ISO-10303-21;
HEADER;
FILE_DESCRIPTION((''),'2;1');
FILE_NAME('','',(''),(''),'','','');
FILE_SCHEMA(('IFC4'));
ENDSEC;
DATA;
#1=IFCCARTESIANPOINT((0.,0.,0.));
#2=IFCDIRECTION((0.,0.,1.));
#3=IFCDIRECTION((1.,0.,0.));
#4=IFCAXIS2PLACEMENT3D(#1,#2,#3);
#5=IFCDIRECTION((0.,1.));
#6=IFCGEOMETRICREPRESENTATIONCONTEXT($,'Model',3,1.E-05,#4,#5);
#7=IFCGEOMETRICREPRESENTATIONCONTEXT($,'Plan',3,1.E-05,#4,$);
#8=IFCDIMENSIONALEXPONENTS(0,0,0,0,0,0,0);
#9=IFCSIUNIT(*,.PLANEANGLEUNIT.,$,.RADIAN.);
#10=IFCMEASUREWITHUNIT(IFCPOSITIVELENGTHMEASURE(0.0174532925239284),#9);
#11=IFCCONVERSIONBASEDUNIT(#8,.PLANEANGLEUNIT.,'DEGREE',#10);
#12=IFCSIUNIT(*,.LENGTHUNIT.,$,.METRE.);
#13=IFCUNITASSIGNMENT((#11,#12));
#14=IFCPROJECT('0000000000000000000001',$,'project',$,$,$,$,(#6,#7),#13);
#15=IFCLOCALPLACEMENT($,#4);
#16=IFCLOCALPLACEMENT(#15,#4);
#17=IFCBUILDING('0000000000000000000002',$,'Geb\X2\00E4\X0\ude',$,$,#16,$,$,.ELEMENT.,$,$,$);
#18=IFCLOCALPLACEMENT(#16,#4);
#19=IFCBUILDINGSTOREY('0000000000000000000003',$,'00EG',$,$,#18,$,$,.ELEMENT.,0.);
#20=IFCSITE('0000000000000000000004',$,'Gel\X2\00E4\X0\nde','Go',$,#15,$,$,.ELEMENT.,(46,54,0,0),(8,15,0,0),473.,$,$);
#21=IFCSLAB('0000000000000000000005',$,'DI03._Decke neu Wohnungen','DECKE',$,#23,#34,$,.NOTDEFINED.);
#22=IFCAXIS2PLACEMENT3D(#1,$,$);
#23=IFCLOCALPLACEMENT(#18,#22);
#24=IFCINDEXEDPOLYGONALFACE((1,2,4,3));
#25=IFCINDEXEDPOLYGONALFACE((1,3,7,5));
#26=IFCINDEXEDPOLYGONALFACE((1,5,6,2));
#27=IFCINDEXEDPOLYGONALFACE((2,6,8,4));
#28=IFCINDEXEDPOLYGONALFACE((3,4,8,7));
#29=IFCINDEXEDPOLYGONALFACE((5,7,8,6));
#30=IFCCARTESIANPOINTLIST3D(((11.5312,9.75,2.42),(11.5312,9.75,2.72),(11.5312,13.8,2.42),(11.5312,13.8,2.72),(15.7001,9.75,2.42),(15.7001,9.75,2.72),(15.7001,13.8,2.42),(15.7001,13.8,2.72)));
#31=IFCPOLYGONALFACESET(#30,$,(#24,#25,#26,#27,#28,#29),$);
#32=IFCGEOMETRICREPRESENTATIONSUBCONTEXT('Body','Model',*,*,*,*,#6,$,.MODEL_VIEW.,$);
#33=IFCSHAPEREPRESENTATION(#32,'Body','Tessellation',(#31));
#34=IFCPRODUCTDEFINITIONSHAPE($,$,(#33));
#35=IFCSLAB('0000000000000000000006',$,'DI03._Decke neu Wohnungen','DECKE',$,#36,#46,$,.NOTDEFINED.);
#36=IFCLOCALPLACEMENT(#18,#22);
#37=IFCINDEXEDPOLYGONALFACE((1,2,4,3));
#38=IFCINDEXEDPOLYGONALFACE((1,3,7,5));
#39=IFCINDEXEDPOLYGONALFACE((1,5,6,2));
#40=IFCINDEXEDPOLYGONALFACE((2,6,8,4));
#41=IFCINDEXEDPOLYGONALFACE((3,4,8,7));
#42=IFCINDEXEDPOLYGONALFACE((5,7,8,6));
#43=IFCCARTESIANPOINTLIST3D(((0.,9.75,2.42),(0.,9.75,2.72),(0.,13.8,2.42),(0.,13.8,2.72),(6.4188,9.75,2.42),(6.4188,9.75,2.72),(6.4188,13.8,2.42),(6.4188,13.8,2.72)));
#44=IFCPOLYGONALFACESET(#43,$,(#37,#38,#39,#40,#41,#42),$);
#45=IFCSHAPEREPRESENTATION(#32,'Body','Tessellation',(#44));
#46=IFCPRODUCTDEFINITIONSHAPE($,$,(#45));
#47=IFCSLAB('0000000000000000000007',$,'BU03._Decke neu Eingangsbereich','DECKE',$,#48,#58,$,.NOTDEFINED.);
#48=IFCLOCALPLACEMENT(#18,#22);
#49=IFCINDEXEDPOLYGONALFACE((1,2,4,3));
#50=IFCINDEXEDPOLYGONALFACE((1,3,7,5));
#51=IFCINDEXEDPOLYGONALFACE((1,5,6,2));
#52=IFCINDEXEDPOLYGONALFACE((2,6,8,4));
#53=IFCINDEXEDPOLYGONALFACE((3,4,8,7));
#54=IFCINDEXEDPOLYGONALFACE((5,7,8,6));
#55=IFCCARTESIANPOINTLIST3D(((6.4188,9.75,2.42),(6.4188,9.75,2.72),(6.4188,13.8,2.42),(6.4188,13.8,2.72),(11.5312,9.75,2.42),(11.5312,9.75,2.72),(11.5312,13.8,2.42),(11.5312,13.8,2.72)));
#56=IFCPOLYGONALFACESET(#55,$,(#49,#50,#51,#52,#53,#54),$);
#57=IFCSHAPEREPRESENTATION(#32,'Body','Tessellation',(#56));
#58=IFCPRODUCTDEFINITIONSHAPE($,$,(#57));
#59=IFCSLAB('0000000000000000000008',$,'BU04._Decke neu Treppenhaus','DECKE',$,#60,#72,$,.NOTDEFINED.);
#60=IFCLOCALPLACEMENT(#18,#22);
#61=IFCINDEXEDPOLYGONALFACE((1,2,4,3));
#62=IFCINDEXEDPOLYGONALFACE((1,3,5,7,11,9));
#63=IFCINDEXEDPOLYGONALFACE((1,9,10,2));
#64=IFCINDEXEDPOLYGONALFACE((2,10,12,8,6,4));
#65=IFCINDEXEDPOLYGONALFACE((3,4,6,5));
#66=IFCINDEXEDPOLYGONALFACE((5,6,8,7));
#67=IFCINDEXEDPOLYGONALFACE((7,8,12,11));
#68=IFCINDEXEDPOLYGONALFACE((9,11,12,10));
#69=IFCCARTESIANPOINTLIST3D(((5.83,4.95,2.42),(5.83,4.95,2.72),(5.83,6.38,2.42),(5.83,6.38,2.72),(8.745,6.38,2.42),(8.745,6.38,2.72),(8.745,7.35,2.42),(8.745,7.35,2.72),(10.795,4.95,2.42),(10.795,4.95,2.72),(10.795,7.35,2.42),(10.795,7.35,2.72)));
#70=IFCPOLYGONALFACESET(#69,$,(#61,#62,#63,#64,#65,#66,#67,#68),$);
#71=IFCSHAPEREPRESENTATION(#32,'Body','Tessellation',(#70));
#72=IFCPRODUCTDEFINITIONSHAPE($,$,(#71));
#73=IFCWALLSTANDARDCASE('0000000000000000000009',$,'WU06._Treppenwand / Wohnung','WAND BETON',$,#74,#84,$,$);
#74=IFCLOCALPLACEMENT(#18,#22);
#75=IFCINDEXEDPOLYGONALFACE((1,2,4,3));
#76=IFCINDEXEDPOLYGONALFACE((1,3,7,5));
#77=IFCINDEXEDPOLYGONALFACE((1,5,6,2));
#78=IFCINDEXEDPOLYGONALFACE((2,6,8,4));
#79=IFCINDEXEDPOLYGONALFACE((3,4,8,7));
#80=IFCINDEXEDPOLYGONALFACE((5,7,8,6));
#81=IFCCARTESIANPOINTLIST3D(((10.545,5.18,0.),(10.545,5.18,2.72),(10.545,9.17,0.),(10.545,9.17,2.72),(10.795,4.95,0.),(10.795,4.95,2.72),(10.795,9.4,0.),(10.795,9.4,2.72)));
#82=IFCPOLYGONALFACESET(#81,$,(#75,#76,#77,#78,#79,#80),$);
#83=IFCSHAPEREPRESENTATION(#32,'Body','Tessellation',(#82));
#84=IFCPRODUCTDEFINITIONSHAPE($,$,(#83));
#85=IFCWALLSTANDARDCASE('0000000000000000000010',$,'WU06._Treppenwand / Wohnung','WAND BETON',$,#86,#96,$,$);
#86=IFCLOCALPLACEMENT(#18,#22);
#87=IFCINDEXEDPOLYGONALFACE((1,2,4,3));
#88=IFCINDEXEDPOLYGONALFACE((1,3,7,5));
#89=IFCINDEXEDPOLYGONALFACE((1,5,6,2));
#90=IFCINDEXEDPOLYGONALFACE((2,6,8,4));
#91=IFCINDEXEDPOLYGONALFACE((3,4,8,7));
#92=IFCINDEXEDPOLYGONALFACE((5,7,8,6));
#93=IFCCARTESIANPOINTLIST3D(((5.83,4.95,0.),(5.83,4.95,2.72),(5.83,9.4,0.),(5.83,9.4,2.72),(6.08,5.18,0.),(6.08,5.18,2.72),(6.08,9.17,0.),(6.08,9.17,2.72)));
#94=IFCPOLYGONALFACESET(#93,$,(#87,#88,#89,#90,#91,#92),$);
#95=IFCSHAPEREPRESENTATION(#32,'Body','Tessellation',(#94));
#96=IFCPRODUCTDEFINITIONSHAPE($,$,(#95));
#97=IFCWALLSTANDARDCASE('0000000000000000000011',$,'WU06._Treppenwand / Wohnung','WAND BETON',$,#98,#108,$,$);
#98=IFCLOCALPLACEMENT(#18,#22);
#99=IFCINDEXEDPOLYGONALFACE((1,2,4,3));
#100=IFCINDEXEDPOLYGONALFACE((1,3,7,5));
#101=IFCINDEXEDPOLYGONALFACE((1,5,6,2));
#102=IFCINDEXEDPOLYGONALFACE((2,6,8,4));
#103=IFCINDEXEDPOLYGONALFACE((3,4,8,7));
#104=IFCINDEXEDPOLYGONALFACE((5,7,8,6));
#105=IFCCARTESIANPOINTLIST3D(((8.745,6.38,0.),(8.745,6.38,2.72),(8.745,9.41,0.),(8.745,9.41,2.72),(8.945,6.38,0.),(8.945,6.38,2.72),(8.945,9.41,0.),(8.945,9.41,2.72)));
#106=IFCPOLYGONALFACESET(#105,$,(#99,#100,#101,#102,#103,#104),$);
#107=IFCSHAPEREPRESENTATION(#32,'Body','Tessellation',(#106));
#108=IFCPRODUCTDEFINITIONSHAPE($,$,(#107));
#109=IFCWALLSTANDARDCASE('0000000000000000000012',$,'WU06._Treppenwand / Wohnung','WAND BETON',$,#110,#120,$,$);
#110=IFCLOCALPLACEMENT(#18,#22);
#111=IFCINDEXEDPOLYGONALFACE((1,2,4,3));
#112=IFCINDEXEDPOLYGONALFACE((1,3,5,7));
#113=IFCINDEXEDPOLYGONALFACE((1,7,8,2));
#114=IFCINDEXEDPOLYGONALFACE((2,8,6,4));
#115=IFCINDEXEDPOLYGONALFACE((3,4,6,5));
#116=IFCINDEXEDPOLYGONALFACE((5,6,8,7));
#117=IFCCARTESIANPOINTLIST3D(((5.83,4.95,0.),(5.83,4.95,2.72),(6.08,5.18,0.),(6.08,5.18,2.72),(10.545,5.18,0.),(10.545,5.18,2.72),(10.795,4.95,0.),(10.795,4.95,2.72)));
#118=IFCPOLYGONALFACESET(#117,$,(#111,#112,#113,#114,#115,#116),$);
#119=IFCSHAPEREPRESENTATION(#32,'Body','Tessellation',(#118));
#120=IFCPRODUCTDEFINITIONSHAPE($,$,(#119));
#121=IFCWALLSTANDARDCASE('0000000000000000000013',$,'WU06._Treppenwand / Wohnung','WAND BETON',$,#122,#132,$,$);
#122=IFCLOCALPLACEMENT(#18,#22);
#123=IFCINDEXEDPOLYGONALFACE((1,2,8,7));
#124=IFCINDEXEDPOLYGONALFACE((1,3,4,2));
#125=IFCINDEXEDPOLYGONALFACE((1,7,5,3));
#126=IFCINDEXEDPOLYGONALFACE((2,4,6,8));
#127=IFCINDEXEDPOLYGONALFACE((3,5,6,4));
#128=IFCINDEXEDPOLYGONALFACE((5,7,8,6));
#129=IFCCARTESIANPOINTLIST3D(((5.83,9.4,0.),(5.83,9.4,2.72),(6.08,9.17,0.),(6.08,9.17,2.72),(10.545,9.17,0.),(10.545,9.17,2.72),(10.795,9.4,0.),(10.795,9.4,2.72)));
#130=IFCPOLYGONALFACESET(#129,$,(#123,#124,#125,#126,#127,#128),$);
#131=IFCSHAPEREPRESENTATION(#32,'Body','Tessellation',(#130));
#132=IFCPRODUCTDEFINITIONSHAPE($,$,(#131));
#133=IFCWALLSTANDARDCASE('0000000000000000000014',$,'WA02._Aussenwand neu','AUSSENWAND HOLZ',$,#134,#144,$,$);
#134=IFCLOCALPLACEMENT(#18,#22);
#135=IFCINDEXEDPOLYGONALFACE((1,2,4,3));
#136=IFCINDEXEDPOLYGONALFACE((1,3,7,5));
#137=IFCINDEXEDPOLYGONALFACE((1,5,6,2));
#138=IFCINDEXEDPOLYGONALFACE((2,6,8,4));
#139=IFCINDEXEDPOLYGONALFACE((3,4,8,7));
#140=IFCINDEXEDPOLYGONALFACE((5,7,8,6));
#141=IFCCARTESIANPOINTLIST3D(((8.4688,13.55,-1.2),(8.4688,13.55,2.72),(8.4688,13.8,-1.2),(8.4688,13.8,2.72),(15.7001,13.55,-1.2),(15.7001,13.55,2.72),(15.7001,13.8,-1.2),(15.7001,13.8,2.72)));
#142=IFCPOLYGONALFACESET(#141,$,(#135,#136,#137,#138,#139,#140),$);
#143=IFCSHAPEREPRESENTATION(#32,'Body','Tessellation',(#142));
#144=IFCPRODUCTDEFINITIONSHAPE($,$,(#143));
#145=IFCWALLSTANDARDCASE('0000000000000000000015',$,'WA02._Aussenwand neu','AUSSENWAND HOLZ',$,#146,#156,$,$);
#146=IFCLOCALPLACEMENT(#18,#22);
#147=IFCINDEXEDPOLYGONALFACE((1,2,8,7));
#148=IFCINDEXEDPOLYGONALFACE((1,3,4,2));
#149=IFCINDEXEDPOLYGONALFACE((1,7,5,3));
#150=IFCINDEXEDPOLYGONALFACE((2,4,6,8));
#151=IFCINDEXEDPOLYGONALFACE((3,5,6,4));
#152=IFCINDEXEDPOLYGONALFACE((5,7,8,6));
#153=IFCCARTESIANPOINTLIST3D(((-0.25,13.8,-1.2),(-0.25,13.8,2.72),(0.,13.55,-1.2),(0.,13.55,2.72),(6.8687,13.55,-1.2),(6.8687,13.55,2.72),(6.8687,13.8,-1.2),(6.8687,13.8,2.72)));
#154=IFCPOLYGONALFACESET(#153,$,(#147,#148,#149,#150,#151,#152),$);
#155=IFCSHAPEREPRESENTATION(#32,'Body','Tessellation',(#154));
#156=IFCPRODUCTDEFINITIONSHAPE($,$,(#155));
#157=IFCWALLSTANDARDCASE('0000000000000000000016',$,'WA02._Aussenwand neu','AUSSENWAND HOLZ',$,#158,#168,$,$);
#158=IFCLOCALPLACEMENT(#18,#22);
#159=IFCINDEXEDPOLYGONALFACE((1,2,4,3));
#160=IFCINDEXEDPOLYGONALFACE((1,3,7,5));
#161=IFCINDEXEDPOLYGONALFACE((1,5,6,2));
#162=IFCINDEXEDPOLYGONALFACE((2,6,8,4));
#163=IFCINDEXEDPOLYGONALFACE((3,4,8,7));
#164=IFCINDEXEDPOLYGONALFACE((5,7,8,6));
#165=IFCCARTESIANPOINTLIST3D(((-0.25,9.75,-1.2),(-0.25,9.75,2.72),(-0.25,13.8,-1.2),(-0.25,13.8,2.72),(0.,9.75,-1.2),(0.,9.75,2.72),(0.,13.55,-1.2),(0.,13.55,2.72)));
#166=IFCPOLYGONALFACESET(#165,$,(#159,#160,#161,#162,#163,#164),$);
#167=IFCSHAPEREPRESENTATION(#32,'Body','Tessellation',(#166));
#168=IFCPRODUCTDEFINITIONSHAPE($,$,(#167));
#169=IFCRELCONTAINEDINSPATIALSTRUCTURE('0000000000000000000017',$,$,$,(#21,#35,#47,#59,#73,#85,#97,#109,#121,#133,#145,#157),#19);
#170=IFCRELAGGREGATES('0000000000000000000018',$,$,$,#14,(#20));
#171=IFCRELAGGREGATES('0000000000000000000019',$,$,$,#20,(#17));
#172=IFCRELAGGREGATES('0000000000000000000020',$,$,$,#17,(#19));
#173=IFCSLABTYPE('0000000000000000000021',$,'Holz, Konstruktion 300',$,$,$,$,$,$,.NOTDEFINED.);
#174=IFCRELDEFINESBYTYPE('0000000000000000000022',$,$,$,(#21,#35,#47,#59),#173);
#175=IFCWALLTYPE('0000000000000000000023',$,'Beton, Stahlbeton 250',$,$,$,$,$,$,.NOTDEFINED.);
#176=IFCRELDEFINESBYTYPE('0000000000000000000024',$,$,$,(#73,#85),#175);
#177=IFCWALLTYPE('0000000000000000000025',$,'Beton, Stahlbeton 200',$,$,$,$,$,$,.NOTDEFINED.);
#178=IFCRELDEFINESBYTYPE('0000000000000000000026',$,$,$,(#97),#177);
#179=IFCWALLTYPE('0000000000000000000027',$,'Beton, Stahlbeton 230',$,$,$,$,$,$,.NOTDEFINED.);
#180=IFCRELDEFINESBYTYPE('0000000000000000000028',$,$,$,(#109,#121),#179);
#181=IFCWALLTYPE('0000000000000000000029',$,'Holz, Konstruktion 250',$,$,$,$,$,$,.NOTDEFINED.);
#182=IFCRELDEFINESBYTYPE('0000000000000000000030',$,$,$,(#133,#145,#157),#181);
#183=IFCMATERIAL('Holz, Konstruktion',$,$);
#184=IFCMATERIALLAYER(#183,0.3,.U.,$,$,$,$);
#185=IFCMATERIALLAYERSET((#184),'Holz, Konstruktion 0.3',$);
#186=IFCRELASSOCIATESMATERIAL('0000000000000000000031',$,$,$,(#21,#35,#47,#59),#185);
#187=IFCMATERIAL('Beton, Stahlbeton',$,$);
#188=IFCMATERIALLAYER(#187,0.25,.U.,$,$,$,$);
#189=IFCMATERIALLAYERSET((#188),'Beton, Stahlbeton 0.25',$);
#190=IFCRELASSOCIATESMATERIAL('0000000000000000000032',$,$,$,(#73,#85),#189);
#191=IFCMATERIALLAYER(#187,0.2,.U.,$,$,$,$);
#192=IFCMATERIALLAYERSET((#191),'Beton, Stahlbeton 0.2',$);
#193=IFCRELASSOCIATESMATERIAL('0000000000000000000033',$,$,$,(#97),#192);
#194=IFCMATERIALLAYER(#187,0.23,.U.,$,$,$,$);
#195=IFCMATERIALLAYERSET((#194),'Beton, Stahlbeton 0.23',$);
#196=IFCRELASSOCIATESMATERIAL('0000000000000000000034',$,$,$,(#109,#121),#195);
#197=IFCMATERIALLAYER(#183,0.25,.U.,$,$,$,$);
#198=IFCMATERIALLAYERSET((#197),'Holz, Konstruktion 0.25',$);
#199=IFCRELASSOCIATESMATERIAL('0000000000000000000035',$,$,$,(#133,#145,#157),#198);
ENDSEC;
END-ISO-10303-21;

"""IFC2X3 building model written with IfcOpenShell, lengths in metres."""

from ifc_helpers import new_model, entity, si_unit, converted_unit, direction, frame, origin_with_axes, place, context, subcontext, project, spatial, polyline, outline, extrude, material, layer, layer_set, layer_usage, type_object, element, save


model = new_model("IFC2X3")

# Units and contexts
model_context = context("Model", 3, precision=1e-05, world=origin_with_axes(), true_north=direction((0.0, 1.0)))
plan_context = context("Plan", 3, precision=1e-05, world=origin_with_axes())
body_context = subcontext(model_context, "Body", "Model", "MODEL_VIEW")
ifc_project = project(units=[converted_unit("PLANEANGLEUNIT", "DEGREE", entity("IfcPositiveLengthMeasure", 0.0174532925239284), si_unit("PLANEANGLEUNIT", "RADIAN"), dimensions=[0, 0, 0, 0, 0, 0, 0]), si_unit("LENGTHUNIT", "METRE")], contexts=[model_context, plan_context])

# Site, building, storey
site_placement = place(None, origin_with_axes())
site = spatial("IfcSite", under=ifc_project, at=site_placement, Name="Gelände", Description="Go", CompositionType="ELEMENT", RefLatitude=(46, 54, 0, 0), RefLongitude=(8, 15, 0, 0), RefElevation=473.0)
building_placement = place(site_placement, origin_with_axes())
building = spatial("IfcBuilding", under=site, at=building_placement, Name="Gebäude", CompositionType="ELEMENT")
storey_placement = place(building_placement, origin_with_axes())
storey = spatial("IfcBuildingStorey", under=building, at=storey_placement, Name="00EG", CompositionType="ELEMENT", Elevation=0.0)

# Slabs
ifc_material_1 = material(Name="Holz, Konstruktion")
ifc_layer_1 = layer(ifc_material_1, 0.3, ventilated="UNKNOWN")
ifc_layer_set_1 = layer_set([ifc_layer_1], Name="Holz, Konstruktion 0.3")
ifc_layer_usage_1 = layer_usage(ifc_layer_set_1, "AXIS3", "NEGATIVE", 0.3)
slab_type = type_object("IfcSlabType", Name="Holz, Konstruktion 300", PredefinedType="NOTDEFINED")
slab_1_placement = place(storey_placement, frame((11.5312, 9.75, 2.72), z_axis=(0.0, 0.0, 1.0), x_axis=(1.0, 0.0, 0.0)))
element("IfcSlab", 1, at=slab_1_placement, inside=storey, type_object=slab_type, material=ifc_layer_usage_1, Name="DI03._Decke neu Wohnungen", Description="DECKE", PredefinedType="NOTDEFINED", context=body_context, shape_type="SweptSolid", body=[
    extrude(outline(polyline([(0.0, 0.0), (4.1689, 0.0), (4.1689, 4.05), (0.0, 4.05), (0.0, 0.0)])), frame((0.0, 0.0, -0.3), z_axis=(0.0, 0.0, 1.0), x_axis=(1.0, 0.0, 0.0)), (0.0, 0.0, 1.0), 0.3),
])
ifc_layer_usage_2 = layer_usage(ifc_layer_set_1, "AXIS3", "NEGATIVE", 0.3)
slab_2_placement = place(storey_placement, frame((0.0, 9.75, 2.72), z_axis=(0.0, 0.0, 1.0), x_axis=(1.0, 0.0, 0.0)))
element("IfcSlab", 2, at=slab_2_placement, inside=storey, type_object=slab_type, material=ifc_layer_usage_2, Name="DI03._Decke neu Wohnungen", Description="DECKE", PredefinedType="NOTDEFINED", context=body_context, shape_type="SweptSolid", body=[
    extrude(outline(polyline([(0.0, 0.0), (6.4188, 0.0), (6.4188, 4.05), (0.0, 4.05), (0.0, 0.0)])), frame((0.0, 0.0, -0.3), z_axis=(0.0, 0.0, 1.0), x_axis=(1.0, 0.0, 0.0)), (0.0, 0.0, 1.0), 0.3),
])
ifc_layer_usage_3 = layer_usage(ifc_layer_set_1, "AXIS3", "NEGATIVE", 0.3)
slab_3_placement = place(storey_placement, frame((6.4188, 9.75, 2.72), z_axis=(0.0, 0.0, 1.0), x_axis=(1.0, 0.0, 0.0)))
element("IfcSlab", 3, at=slab_3_placement, inside=storey, type_object=slab_type, material=ifc_layer_usage_3, Name="BU03._Decke neu Eingangsbereich", Description="DECKE", PredefinedType="NOTDEFINED", context=body_context, shape_type="SweptSolid", body=[
    extrude(outline(polyline([(0.0, 0.0), (5.1125, 0.0), (5.1125, 4.05), (0.0, 4.05), (0.0, 0.0)])), frame((0.0, 0.0, -0.3), z_axis=(0.0, 0.0, 1.0), x_axis=(1.0, 0.0, 0.0)), (0.0, 0.0, 1.0), 0.3),
])
ifc_layer_usage_4 = layer_usage(ifc_layer_set_1, "AXIS3", "NEGATIVE", 0.3)
slab_4_placement = place(storey_placement, frame((10.795, 7.35, 2.72), z_axis=(0.0, 0.0, 1.0), x_axis=(1.0, 0.0, 0.0)))
element("IfcSlab", 4, at=slab_4_placement, inside=storey, type_object=slab_type, material=ifc_layer_usage_4, Name="BU04._Decke neu Treppenhaus", Description="DECKE", PredefinedType="NOTDEFINED", context=body_context, shape_type="SweptSolid", body=[
    extrude(outline(polyline([(0.0, 0.0), (-2.05, 0.0), (-2.05, -0.97), (-4.965, -0.97), (-4.965, -2.4), (0.0, -2.4), (0.0, 0.0)])), frame((0.0, 0.0, -0.3), z_axis=(0.0, 0.0, 1.0), x_axis=(1.0, 0.0, 0.0)), (0.0, 0.0, 1.0), 0.3),
])

# Walls
ifc_material_2 = material(Name="Beton, Stahlbeton")
ifc_layer_2 = layer(ifc_material_2, 0.25, ventilated="UNKNOWN")
ifc_layer_set_2 = layer_set([ifc_layer_2], Name="Beton, Stahlbeton 0.25")
ifc_layer_usage_5 = layer_usage(ifc_layer_set_2, "AXIS2", "POSITIVE", -0.25)
wall_type_1 = type_object("IfcWallType", Name="Beton, Stahlbeton 250", PredefinedType="NOTDEFINED")
wall_1_placement = place(storey_placement, frame((10.545, 5.18, 0.0), z_axis=(0.0, 0.0, 1.0), x_axis=(0.0, 1.0, 0.0)))
element("IfcWallStandardCase", 5, at=wall_1_placement, inside=storey, type_object=wall_type_1, material=ifc_layer_usage_5, Name="WU06._Treppenwand / Wohnung", Description="WAND BETON", context=body_context, shape_type="SweptSolid", body=[
    extrude(outline(polyline([(-0.23, -0.25), (4.22, -0.25), (3.99, 0.0), (0.0, 0.0), (-0.23, -0.25)])), origin_with_axes(), (0.0, 0.0, 1.0), 2.72),
])
ifc_layer_usage_6 = layer_usage(ifc_layer_set_2, "AXIS2", "POSITIVE", -0.25)
wall_2_placement = place(storey_placement, frame((6.08, 9.17, 0.0), z_axis=(0.0, 0.0, 1.0), x_axis=(0.0, -1.0, 0.0)))
element("IfcWallStandardCase", 6, at=wall_2_placement, inside=storey, type_object=wall_type_1, material=ifc_layer_usage_6, Name="WU06._Treppenwand / Wohnung", Description="WAND BETON", context=body_context, shape_type="SweptSolid", body=[
    extrude(outline(polyline([(-0.23, -0.25), (4.22, -0.25), (3.99, 0.0), (0.0, 0.0), (-0.23, -0.25)])), origin_with_axes(), (0.0, 0.0, 1.0), 2.72),
])
ifc_layer_3 = layer(ifc_material_2, 0.2, ventilated="UNKNOWN")
ifc_layer_set_3 = layer_set([ifc_layer_3], Name="Beton, Stahlbeton 0.2")
ifc_layer_usage_7 = layer_usage(ifc_layer_set_3, "AXIS2", "NEGATIVE", 0.2)
wall_type_2 = type_object("IfcWallType", Name="Beton, Stahlbeton 200", PredefinedType="NOTDEFINED")
wall_3_placement = place(storey_placement, frame((8.945, 6.38, 0.0), z_axis=(0.0, 0.0, 1.0), x_axis=(0.0, 1.0, 0.0)))
element("IfcWallStandardCase", 7, at=wall_3_placement, inside=storey, type_object=wall_type_2, material=ifc_layer_usage_7, Name="WU06._Treppenwand / Wohnung", Description="WAND BETON", context=body_context, shape_type="SweptSolid", body=[
    extrude(outline(polyline([(0.0, 0.0), (3.03, 0.0), (3.03, 0.2), (0.0, 0.2), (0.0, 0.0)])), origin_with_axes(), (0.0, 0.0, 1.0), 2.72),
])
ifc_layer_4 = layer(ifc_material_2, 0.23, ventilated="UNKNOWN")
ifc_layer_set_4 = layer_set([ifc_layer_4], Name="Beton, Stahlbeton 0.23")
ifc_layer_usage_8 = layer_usage(ifc_layer_set_4, "AXIS2", "POSITIVE", -0.23)
wall_type_3 = type_object("IfcWallType", Name="Beton, Stahlbeton 230", PredefinedType="NOTDEFINED")
wall_4_placement = place(storey_placement, frame((6.08, 5.18, 0.0), z_axis=(0.0, 0.0, 1.0), x_axis=(1.0, 0.0, 0.0)))
element("IfcWallStandardCase", 8, at=wall_4_placement, inside=storey, type_object=wall_type_3, material=ifc_layer_usage_8, Name="WU06._Treppenwand / Wohnung", Description="WAND BETON", context=body_context, shape_type="SweptSolid", body=[
    extrude(outline(polyline([(-0.25, -0.23), (4.715, -0.23), (4.465, 0.0), (0.0, 0.0), (-0.25, -0.23)])), origin_with_axes(), (0.0, 0.0, 1.0), 2.72),
])
ifc_layer_usage_9 = layer_usage(ifc_layer_set_4, "AXIS2", "POSITIVE", -0.23)
wall_5_placement = place(storey_placement, frame((10.545, 9.17, 0.0), z_axis=(0.0, 0.0, 1.0), x_axis=(-1.0, 0.0, 0.0)))
element("IfcWallStandardCase", 9, at=wall_5_placement, inside=storey, type_object=wall_type_3, material=ifc_layer_usage_9, Name="WU06._Treppenwand / Wohnung", Description="WAND BETON", context=body_context, shape_type="SweptSolid", body=[
    extrude(outline(polyline([(-0.25, -0.23), (4.715, -0.23), (4.465, 0.0), (0.0, 0.0), (-0.25, -0.23)])), origin_with_axes(), (0.0, 0.0, 1.0), 2.72),
])
ifc_layer_5 = layer(ifc_material_1, 0.25, ventilated="UNKNOWN")
ifc_layer_set_5 = layer_set([ifc_layer_5], Name="Holz, Konstruktion 0.25")
ifc_layer_usage_10 = layer_usage(ifc_layer_set_5, "AXIS2", "NEGATIVE", 0.0)
wall_type_4 = type_object("IfcWallType", Name="Holz, Konstruktion 250", PredefinedType="NOTDEFINED")
wall_6_placement = place(storey_placement, frame((8.4688, 13.8, -1.2), z_axis=(0.0, 0.0, 1.0), x_axis=(1.0, 0.0, 0.0)))
element("IfcWallStandardCase", 10, at=wall_6_placement, inside=storey, type_object=wall_type_4, material=ifc_layer_usage_10, Name="WA02._Aussenwand neu", Description="AUSSENWAND HOLZ", context=body_context, shape_type="SweptSolid", body=[
    extrude(outline(polyline([(0.0, -0.25), (7.2314, -0.25), (7.2314, 0.0), (0.0, 0.0), (0.0, -0.25)])), origin_with_axes(), (0.0, 0.0, 1.0), 3.92),
])
ifc_layer_usage_11 = layer_usage(ifc_layer_set_5, "AXIS2", "NEGATIVE", 0.0)
wall_7_placement = place(storey_placement, frame((-0.25, 13.8, -1.2), z_axis=(0.0, 0.0, 1.0), x_axis=(1.0, 0.0, 0.0)))
element("IfcWallStandardCase", 11, at=wall_7_placement, inside=storey, type_object=wall_type_4, material=ifc_layer_usage_11, Name="WA02._Aussenwand neu", Description="AUSSENWAND HOLZ", context=body_context, shape_type="SweptSolid", body=[
    extrude(outline(polyline([(0.25, -0.25), (7.1187, -0.25), (7.1187, 0.0), (0.0, 0.0), (0.25, -0.25)])), origin_with_axes(), (0.0, 0.0, 1.0), 3.92),
])
ifc_layer_usage_12 = layer_usage(ifc_layer_set_5, "AXIS2", "NEGATIVE", 0.0)
wall_8_placement = place(storey_placement, frame((-0.25, 9.75, -1.2), z_axis=(0.0, 0.0, 1.0), x_axis=(0.0, 1.0, 0.0)))
element("IfcWallStandardCase", 12, at=wall_8_placement, inside=storey, type_object=wall_type_4, material=ifc_layer_usage_12, Name="WA02._Aussenwand neu", Description="AUSSENWAND HOLZ", context=body_context, shape_type="SweptSolid", body=[
    extrude(outline(polyline([(0.0, -0.25), (3.8, -0.25), (4.05, 0.0), (0.0, 0.0), (0.0, -0.25)])), origin_with_axes(), (0.0, 0.0, 1.0), 3.92),
])

save(model, "model.ifc")
